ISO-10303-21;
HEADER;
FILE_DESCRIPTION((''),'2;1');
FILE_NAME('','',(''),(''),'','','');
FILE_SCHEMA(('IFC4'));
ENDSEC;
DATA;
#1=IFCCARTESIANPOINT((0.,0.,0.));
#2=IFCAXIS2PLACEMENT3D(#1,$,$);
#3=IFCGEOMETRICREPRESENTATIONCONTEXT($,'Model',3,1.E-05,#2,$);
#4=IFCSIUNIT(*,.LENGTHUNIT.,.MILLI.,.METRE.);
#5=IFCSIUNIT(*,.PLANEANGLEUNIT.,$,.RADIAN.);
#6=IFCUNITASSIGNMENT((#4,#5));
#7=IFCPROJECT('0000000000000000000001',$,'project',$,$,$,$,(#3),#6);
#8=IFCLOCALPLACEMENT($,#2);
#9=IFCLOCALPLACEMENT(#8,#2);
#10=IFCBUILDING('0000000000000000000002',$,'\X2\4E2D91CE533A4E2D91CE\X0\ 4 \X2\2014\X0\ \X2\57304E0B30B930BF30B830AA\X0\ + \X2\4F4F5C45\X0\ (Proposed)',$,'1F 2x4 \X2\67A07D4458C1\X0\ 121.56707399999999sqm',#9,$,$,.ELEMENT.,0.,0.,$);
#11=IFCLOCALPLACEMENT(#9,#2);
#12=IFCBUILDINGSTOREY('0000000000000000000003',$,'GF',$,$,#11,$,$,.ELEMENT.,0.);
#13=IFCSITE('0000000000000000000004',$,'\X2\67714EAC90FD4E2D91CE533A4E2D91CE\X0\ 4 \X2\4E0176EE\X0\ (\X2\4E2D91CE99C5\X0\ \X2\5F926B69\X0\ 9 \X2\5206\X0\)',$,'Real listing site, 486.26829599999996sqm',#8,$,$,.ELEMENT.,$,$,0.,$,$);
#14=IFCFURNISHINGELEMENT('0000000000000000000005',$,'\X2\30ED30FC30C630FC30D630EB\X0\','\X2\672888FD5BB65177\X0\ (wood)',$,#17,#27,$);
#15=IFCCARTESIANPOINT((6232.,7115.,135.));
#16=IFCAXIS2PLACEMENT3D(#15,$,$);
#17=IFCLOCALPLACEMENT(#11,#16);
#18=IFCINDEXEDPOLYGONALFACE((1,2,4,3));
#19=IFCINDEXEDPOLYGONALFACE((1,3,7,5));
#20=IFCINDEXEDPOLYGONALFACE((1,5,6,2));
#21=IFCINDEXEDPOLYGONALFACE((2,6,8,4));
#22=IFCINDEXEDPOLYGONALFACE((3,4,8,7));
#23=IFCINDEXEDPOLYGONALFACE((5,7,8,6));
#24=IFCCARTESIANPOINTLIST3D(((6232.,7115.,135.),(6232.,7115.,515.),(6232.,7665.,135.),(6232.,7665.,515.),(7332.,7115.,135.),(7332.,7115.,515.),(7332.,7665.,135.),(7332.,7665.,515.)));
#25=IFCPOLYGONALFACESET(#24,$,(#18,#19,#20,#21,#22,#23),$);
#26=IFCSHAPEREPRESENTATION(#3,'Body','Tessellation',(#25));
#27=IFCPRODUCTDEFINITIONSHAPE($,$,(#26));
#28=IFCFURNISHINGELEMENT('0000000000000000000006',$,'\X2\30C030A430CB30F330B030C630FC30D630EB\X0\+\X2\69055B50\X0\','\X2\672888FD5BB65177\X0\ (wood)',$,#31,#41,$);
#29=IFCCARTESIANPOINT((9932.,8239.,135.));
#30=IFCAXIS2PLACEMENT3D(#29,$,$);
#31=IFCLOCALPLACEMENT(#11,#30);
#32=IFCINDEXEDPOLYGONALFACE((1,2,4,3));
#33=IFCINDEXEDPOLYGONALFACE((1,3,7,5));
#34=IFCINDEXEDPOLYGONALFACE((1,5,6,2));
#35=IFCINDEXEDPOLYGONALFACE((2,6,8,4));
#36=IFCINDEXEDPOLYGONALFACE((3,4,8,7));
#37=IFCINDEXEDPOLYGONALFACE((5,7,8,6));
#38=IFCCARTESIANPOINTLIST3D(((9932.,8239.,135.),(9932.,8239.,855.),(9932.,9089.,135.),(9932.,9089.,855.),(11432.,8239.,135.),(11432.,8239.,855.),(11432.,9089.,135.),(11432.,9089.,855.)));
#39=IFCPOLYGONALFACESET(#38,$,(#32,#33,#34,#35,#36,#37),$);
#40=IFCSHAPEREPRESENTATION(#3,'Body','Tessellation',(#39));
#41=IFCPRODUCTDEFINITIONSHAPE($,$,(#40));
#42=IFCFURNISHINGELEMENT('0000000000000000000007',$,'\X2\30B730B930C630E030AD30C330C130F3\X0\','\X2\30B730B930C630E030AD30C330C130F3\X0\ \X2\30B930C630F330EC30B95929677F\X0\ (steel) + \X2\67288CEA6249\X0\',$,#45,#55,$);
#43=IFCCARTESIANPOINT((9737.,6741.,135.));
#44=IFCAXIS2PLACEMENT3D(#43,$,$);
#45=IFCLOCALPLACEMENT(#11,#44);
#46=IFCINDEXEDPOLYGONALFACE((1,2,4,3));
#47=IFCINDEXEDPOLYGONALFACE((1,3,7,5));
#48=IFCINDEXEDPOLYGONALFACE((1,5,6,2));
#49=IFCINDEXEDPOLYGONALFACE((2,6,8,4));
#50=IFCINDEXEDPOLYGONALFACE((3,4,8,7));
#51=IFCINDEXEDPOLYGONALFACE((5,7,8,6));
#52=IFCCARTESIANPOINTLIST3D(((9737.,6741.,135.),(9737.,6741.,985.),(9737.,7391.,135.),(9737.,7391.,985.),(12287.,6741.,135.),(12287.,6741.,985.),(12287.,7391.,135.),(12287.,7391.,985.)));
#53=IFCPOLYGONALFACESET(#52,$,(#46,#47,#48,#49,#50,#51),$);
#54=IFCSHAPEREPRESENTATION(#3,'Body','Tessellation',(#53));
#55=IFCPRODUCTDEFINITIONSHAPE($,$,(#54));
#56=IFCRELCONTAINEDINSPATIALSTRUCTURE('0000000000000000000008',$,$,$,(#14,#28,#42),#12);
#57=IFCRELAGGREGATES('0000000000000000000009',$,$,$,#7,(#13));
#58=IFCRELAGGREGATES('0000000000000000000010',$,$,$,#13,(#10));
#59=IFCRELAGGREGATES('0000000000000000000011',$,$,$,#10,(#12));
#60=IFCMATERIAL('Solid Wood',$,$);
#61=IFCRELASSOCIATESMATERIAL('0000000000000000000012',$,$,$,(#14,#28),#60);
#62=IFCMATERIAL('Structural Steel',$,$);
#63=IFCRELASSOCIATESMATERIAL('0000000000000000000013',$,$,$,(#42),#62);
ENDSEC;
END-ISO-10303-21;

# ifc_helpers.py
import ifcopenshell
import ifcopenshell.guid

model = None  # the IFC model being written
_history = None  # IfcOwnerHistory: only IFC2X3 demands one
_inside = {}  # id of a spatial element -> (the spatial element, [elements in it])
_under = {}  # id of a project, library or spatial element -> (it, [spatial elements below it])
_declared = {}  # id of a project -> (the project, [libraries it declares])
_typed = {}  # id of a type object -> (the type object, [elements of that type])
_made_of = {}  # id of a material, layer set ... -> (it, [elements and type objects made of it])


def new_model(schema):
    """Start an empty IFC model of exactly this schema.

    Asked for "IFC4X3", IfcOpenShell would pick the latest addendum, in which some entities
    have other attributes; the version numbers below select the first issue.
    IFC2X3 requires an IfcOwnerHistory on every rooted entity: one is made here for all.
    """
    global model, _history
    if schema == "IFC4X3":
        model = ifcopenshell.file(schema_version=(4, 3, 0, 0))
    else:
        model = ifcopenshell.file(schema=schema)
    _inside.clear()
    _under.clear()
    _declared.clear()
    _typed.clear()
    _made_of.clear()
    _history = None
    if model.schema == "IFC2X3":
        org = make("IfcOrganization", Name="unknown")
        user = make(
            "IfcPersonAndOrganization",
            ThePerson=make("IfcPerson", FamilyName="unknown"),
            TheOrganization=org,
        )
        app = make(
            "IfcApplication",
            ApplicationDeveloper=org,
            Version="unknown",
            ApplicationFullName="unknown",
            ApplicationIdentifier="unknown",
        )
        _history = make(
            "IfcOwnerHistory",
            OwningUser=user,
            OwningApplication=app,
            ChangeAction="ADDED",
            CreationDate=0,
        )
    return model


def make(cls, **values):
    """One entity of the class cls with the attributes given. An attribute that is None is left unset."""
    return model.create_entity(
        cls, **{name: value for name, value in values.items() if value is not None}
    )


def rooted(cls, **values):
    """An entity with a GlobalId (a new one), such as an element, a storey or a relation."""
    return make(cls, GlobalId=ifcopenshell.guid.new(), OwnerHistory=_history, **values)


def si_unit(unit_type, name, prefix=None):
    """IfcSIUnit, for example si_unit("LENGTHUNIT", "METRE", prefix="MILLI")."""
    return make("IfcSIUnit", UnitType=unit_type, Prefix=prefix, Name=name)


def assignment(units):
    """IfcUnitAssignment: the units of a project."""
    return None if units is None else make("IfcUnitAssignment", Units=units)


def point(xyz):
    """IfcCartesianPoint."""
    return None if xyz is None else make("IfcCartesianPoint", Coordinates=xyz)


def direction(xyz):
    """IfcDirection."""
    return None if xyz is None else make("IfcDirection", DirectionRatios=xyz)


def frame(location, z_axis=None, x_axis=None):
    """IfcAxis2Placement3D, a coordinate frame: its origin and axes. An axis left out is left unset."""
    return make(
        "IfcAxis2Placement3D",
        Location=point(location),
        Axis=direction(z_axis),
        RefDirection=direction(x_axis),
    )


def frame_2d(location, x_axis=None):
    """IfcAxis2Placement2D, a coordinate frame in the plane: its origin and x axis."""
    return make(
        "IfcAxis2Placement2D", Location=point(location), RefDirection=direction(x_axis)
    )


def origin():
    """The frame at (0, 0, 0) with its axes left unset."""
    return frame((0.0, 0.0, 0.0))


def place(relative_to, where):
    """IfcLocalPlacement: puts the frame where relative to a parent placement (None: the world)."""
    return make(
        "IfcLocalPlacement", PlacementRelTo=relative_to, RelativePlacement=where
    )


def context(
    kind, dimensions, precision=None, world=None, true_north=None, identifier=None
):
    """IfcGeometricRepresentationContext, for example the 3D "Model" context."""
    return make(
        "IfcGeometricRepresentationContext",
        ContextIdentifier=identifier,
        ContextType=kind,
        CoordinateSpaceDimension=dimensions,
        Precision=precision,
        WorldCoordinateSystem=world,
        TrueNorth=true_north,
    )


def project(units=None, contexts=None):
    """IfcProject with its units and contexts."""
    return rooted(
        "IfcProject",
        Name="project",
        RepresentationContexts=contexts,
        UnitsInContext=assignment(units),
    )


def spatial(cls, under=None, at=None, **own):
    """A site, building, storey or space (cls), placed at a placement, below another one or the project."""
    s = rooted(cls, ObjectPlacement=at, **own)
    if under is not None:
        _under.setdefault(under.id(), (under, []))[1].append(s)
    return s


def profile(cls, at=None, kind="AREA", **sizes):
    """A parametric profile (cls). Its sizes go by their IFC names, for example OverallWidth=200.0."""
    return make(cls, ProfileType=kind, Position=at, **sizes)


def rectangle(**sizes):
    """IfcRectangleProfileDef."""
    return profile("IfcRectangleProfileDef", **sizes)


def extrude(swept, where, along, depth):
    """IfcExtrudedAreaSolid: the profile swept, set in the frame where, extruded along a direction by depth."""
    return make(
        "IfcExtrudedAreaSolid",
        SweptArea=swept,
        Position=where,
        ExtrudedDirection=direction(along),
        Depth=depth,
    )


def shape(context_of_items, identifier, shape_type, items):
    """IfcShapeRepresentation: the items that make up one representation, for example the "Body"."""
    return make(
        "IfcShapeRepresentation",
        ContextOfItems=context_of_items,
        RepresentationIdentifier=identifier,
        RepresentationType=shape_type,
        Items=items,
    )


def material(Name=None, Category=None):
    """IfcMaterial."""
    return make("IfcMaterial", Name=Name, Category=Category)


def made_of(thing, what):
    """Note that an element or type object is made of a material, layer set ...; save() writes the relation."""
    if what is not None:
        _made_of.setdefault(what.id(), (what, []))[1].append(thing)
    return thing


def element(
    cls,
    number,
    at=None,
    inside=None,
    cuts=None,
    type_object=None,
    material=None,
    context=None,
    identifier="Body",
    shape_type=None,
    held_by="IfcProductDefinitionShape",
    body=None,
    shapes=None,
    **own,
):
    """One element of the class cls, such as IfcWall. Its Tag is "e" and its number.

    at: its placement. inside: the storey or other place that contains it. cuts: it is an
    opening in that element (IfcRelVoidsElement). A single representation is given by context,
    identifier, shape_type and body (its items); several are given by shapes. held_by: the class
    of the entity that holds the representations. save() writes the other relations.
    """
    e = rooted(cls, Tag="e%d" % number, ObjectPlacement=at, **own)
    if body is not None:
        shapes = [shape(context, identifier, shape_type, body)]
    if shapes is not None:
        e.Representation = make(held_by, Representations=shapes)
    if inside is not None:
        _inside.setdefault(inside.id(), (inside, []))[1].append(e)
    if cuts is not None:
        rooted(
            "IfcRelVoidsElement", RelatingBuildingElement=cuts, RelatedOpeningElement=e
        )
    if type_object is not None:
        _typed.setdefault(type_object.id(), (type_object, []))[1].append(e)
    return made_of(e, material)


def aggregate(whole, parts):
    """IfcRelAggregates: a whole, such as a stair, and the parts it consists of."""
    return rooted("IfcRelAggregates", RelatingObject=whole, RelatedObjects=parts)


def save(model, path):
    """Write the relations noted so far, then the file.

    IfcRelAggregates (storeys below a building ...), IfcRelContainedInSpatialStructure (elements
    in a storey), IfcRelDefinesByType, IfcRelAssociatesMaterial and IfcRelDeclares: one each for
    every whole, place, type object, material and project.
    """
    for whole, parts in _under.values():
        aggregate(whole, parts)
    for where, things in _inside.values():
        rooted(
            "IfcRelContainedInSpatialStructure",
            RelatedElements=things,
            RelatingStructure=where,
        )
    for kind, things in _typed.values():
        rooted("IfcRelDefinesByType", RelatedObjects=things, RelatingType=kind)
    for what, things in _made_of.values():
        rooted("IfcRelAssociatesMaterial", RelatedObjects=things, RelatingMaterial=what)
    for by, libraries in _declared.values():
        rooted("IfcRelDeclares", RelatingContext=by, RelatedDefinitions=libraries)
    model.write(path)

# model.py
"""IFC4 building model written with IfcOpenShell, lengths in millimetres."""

from ifc_helpers import new_model, si_unit, frame, frame_2d, origin, place, context, project, spatial, rectangle, extrude, material, element, save


model = new_model("IFC4")

# Units and contexts
model_context = context("Model", 3, precision=1e-05, world=origin())
ifc_project = project(units=[si_unit("LENGTHUNIT", "METRE", prefix="MILLI"), si_unit("PLANEANGLEUNIT", "RADIAN")], contexts=[model_context])

# Site, building, storey
site_placement = place(None, origin())
site = spatial("IfcSite", under=ifc_project, at=site_placement, Name="東京都中野区中野 4 丁目 (中野駅 徒歩 9 分)", ObjectType="Real listing site, 486.26829599999996sqm", CompositionType="ELEMENT", RefElevation=0.0)
building_placement = place(site_placement, origin())
building = spatial("IfcBuilding", under=site, at=building_placement, Name="中野区中野 4 — 地下スタジオ + 住居 (Proposed)", ObjectType="1F 2x4 枠組壁 121.56707399999999sqm", CompositionType="ELEMENT", ElevationOfRefHeight=0.0, ElevationOfTerrain=0.0)
storey_placement = place(building_placement, origin())
storey = spatial("IfcBuildingStorey", under=building, at=storey_placement, Name="GF", CompositionType="ELEMENT", Elevation=0.0)

# Shared definitions
ifc_material_1 = material(Name="Solid Wood")

# Shared definitions
ifc_material_2 = material(Name="Structural Steel")

# Furnishing elements
furnishing_1_placement = place(storey_placement, frame((6232.0, 7115.0, 135.0)))
element("IfcFurnishingElement", 1, at=furnishing_1_placement, inside=storey, material=ifc_material_1, Name="ローテーブル", Description="木製家具 (wood)", context=model_context, shape_type="SweptSolid", body=[
    extrude(rectangle(XDim=1100.0, YDim=550.0, at=frame_2d((550.0, 275.0))), frame((6232.0, 7115.0, 135.0)), (0.0, 0.0, 1.0), 380.0),
])
furnishing_2_placement = place(storey_placement, frame((9932.0, 8239.0, 135.0)))
element("IfcFurnishingElement", 2, at=furnishing_2_placement, inside=storey, material=ifc_material_1, Name="ダイニングテーブル+椅子", Description="木製家具 (wood)", context=model_context, shape_type="SweptSolid", body=[
    extrude(rectangle(XDim=1500.0, YDim=850.0, at=frame_2d((750.0, 425.0))), frame((9932.0, 8239.0, 135.0)), (0.0, 0.0, 1.0), 720.0),
])
furnishing_3_placement = place(storey_placement, frame((9737.0, 6741.0, 135.0)))
element("IfcFurnishingElement", 3, at=furnishing_3_placement, inside=storey, material=ifc_material_2, Name="システムキッチン", Description="システムキッチン ステンレス天板 (steel) + 木質扉", context=model_context, shape_type="SweptSolid", body=[
    extrude(rectangle(XDim=2550.0, YDim=650.0, at=frame_2d((1275.0, 325.0))), frame((9737.0, 6741.0, 135.0)), (0.0, 0.0, 1.0), 850.0),
])

save(model, "model.ifc")
